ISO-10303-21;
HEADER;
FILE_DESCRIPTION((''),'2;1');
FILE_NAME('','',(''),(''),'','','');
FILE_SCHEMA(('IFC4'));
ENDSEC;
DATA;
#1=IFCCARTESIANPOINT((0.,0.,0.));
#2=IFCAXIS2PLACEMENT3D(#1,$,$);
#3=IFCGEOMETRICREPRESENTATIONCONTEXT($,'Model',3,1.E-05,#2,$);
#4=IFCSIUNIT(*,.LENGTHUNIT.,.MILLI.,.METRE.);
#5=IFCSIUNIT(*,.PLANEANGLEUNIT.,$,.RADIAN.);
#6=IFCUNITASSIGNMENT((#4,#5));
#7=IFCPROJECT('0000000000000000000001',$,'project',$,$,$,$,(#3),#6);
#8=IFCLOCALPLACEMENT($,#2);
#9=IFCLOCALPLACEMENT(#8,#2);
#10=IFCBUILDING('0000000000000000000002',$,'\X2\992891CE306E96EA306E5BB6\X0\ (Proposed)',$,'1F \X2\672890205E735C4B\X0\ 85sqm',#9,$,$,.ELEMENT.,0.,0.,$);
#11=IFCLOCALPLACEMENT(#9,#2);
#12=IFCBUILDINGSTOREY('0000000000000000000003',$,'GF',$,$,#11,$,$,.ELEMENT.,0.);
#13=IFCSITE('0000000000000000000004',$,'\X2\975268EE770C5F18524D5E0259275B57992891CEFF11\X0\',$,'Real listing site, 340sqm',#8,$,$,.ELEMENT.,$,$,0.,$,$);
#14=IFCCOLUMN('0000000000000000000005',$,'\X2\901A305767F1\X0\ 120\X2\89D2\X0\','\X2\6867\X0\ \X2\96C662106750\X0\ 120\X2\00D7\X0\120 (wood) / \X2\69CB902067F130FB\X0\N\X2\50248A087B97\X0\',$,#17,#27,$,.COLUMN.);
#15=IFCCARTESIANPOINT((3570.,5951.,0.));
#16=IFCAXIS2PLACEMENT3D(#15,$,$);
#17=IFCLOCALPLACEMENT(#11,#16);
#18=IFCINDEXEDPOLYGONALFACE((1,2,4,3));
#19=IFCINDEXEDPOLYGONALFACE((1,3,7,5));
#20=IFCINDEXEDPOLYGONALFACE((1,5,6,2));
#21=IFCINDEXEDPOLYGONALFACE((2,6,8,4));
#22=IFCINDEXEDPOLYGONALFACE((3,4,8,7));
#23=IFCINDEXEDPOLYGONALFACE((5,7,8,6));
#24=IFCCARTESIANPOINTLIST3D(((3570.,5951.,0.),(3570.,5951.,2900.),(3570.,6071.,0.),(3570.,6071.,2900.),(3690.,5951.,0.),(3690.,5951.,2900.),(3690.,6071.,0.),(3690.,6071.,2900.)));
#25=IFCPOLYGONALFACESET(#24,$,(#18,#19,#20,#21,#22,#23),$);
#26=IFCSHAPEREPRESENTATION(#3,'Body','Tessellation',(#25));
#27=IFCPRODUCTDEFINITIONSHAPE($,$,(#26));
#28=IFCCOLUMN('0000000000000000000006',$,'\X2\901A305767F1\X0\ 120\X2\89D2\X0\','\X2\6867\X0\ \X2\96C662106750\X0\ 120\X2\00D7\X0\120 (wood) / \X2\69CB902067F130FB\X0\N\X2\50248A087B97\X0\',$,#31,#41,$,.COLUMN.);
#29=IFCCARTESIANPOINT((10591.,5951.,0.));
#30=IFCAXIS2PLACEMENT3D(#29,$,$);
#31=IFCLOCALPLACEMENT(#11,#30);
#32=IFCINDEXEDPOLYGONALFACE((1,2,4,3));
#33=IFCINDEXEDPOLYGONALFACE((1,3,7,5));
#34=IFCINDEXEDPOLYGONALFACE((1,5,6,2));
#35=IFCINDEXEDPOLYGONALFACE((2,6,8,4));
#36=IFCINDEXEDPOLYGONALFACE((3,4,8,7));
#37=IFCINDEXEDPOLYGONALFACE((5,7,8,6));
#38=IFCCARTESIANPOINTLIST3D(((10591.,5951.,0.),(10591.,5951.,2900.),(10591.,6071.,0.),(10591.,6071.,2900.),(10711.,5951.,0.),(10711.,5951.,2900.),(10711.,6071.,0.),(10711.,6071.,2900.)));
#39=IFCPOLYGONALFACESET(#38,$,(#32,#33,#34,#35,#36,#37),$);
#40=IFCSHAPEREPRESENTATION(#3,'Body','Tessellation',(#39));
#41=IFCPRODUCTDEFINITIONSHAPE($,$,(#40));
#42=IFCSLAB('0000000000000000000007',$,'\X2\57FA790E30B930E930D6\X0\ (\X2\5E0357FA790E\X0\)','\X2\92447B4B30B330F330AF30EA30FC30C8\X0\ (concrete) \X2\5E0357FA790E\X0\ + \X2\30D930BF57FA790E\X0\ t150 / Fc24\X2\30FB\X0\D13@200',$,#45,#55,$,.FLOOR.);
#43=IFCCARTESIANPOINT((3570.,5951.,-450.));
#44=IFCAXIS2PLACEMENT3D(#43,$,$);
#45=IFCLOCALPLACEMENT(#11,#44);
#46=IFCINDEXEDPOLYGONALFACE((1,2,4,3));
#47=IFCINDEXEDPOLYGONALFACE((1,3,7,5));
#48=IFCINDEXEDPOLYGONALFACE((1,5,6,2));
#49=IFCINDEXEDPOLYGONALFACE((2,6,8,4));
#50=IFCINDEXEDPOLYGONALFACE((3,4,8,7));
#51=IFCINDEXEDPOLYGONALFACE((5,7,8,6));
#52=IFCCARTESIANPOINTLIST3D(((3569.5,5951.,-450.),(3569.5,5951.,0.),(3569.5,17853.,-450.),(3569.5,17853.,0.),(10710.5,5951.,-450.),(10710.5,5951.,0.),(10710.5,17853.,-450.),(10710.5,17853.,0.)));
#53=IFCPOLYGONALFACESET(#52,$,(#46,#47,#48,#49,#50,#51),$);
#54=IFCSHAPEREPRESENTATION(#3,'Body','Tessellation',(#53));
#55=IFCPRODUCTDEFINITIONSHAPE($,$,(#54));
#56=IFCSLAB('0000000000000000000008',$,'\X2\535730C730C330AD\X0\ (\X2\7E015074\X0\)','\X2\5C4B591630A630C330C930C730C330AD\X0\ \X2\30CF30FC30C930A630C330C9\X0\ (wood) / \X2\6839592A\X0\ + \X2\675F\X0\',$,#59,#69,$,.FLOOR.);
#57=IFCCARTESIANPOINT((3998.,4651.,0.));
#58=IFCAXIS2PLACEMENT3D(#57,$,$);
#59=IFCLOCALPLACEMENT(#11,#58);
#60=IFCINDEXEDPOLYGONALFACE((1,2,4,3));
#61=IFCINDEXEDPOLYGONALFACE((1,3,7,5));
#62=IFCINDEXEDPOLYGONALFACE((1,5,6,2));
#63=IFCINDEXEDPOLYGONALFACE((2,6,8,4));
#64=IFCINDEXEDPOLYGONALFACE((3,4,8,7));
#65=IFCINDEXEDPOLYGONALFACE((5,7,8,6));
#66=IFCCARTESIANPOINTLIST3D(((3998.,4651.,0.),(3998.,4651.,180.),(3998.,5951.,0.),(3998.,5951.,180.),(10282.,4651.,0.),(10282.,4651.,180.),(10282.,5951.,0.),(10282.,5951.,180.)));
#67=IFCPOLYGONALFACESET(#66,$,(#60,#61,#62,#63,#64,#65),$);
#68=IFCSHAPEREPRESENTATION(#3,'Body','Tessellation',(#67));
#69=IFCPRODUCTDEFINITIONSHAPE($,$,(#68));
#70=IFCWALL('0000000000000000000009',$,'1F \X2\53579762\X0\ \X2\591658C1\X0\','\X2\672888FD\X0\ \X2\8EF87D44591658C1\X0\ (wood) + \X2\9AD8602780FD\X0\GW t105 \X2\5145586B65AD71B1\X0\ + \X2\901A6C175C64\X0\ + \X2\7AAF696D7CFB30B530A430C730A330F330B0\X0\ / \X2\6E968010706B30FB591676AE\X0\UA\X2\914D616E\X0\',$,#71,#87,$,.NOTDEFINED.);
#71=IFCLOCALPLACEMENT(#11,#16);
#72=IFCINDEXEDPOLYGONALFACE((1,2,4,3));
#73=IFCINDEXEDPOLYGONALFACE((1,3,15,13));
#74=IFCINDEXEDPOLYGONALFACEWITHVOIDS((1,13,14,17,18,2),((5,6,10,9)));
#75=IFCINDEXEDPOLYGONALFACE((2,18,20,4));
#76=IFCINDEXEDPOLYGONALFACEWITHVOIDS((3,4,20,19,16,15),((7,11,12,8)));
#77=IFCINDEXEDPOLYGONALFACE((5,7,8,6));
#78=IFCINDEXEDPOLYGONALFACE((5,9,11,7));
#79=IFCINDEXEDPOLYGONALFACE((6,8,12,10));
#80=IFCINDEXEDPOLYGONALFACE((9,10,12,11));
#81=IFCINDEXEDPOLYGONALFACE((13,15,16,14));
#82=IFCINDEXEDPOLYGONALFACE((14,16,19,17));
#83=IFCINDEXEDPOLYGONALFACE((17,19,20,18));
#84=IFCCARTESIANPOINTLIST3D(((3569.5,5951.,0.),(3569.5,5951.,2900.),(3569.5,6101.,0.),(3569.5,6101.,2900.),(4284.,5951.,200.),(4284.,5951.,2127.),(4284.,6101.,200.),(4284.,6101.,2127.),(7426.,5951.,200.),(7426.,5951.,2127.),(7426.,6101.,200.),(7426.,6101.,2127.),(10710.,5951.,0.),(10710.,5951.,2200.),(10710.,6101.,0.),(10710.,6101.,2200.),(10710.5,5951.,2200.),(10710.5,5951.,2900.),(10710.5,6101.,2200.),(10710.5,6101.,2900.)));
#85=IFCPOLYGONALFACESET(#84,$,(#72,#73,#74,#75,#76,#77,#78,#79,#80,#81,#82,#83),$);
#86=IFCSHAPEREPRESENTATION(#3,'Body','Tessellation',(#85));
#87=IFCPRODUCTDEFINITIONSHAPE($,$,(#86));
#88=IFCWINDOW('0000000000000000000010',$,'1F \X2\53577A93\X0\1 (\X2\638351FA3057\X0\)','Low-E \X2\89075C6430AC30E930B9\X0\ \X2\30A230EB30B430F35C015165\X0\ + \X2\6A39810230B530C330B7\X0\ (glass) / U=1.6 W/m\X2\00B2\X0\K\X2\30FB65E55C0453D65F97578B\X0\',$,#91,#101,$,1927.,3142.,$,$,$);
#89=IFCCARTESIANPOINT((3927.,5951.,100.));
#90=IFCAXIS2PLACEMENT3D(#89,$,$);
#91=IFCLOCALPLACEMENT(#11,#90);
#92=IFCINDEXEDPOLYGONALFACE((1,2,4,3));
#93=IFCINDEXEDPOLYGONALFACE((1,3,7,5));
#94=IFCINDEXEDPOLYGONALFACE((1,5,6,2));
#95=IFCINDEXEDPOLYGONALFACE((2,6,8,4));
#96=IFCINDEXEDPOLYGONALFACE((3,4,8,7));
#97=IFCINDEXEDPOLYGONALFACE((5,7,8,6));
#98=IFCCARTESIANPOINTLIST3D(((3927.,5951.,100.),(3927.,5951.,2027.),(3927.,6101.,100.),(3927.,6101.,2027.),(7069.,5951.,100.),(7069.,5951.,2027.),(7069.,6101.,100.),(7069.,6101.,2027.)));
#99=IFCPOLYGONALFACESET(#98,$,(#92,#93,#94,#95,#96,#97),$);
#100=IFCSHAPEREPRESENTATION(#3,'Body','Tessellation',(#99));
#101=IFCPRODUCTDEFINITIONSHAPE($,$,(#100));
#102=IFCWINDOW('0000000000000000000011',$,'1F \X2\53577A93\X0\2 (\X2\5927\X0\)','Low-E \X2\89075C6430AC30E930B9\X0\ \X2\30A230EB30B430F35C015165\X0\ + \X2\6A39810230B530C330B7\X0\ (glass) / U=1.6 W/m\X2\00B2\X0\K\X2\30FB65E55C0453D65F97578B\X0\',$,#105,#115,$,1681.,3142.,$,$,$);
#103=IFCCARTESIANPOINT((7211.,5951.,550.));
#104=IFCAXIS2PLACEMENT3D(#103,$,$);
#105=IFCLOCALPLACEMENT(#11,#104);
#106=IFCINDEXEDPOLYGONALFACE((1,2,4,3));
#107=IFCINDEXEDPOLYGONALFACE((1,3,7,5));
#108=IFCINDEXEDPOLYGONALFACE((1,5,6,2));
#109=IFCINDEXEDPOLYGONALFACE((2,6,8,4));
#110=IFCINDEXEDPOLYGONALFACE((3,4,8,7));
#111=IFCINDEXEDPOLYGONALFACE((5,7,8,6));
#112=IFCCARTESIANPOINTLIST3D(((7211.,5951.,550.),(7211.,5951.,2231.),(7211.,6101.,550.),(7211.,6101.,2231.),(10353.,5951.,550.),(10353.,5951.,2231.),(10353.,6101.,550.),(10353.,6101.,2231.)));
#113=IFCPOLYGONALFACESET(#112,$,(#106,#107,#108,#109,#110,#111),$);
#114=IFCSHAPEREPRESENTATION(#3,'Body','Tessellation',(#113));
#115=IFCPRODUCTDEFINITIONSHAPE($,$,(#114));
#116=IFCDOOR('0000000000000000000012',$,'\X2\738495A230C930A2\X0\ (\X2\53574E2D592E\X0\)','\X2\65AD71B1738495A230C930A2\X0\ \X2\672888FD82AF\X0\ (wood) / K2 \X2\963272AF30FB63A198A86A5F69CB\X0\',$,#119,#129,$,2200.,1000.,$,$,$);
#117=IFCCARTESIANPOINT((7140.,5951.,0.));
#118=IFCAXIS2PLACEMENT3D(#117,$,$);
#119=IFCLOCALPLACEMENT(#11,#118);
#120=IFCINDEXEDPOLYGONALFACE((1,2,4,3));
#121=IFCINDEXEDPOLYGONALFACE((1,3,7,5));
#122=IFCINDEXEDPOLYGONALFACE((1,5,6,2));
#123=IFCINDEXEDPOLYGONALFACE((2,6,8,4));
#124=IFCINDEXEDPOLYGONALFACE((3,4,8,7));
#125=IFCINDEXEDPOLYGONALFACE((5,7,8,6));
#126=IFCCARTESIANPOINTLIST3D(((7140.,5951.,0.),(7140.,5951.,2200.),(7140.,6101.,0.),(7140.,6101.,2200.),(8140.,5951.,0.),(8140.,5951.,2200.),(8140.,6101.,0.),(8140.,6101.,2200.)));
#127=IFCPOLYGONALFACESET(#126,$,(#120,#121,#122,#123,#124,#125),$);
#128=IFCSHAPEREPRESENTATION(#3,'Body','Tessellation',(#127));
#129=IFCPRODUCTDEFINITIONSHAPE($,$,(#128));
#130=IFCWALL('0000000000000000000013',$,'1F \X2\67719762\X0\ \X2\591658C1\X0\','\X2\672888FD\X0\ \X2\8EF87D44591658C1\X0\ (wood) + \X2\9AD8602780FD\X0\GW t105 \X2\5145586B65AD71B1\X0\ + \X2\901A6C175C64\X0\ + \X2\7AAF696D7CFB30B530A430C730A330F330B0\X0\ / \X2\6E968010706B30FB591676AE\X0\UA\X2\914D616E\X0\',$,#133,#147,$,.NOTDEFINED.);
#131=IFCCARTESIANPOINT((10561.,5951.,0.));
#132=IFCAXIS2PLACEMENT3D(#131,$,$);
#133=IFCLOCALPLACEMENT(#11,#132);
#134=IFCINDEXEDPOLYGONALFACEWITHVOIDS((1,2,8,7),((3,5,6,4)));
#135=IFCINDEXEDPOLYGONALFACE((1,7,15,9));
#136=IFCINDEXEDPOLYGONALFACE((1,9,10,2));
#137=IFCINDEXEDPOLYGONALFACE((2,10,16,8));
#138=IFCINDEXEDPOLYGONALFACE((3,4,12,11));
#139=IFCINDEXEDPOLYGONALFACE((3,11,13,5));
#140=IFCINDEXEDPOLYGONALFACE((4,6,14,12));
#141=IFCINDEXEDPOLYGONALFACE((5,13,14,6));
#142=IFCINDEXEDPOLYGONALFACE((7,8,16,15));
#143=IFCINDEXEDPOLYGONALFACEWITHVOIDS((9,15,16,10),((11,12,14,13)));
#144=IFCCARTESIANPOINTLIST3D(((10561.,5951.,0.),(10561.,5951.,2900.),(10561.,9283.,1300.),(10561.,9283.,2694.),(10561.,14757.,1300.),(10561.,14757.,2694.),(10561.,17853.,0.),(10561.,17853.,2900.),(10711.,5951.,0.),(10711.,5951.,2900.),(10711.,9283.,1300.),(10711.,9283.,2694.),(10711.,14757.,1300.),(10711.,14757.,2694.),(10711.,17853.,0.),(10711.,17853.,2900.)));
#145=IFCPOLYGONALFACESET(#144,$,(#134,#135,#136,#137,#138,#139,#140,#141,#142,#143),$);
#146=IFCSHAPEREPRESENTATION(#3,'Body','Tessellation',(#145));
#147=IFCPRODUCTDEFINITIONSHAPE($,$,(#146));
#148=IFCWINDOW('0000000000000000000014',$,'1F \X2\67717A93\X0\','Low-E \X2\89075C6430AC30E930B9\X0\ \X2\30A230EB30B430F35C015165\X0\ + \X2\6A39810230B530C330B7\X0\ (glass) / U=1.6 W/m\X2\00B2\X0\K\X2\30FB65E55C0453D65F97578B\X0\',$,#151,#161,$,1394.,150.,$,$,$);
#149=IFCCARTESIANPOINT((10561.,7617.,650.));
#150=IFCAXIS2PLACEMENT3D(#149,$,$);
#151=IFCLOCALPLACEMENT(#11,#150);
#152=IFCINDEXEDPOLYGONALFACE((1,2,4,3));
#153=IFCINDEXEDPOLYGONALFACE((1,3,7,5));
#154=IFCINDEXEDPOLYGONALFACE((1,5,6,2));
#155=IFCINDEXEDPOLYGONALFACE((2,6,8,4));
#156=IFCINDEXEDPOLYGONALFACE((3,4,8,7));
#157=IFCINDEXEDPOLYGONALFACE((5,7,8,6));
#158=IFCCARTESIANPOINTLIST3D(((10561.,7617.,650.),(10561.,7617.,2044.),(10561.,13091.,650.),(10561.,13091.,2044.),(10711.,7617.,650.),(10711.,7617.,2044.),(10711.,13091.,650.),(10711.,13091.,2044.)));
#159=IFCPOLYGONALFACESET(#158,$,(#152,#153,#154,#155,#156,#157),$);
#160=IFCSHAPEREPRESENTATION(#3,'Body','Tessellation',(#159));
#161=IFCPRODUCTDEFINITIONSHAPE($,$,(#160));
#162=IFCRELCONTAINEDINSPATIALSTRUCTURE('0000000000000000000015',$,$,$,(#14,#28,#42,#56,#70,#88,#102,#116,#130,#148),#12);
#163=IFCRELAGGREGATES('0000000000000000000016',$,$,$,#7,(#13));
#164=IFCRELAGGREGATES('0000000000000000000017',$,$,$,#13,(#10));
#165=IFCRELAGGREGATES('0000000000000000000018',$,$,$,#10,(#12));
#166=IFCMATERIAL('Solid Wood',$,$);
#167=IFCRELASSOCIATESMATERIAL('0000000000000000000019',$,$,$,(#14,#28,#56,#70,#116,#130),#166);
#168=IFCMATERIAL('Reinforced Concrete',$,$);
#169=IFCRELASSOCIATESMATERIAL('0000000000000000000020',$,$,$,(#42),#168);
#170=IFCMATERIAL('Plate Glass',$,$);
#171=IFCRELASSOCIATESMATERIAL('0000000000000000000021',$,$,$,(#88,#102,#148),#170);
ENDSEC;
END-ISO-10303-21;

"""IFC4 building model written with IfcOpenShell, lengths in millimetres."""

from ifc_helpers import new_model, si_unit, frame, frame_2d, origin, place, context, project, spatial, rectangle, extrude, material, element, fill, save


model = new_model("IFC4")

# Units and contexts
model_context = context("Model", 3, precision=1e-05, world=origin())
ifc_project = project(units=[si_unit("LENGTHUNIT", "METRE", prefix="MILLI"), si_unit("PLANEANGLEUNIT", "RADIAN")], contexts=[model_context])

# Site, building, storey
site_placement = place(None, origin())
site = spatial("IfcSite", under=ifc_project, at=site_placement, Name="青森県弘前市大字館野１", ObjectType="Real listing site, 340sqm", CompositionType="ELEMENT", RefElevation=0.0)
building_placement = place(site_placement, origin())
building = spatial("IfcBuilding", under=site, at=building_placement, Name="館野の雪の家 (Proposed)", ObjectType="1F 木造平屋 85sqm", CompositionType="ELEMENT", ElevationOfRefHeight=0.0, ElevationOfTerrain=0.0)
storey_placement = place(building_placement, origin())
storey = spatial("IfcBuildingStorey", under=building, at=storey_placement, Name="GF", CompositionType="ELEMENT", Elevation=0.0)

# Columns
ifc_material_1 = material(Name="Solid Wood")
column_1_placement = place(storey_placement, frame((3570.0, 5951.0, 0.0)))
element("IfcColumn", 1, at=column_1_placement, inside=storey, material=ifc_material_1, Name="通し柱 120角", Description="桧 集成材 120×120 (wood) / 構造柱・N値計算", PredefinedType="COLUMN", context=model_context, shape_type="SweptSolid", body=[
    extrude(rectangle(XDim=120.0, YDim=120.0, at=frame_2d((60.0, 60.0))), frame((3570.0, 5951.0, 0.0)), (0.0, 0.0, 1.0), 2900.0),
])
column_2_placement = place(storey_placement, frame((10591.0, 5951.0, 0.0)))
element("IfcColumn", 2, at=column_2_placement, inside=storey, material=ifc_material_1, Name="通し柱 120角", Description="桧 集成材 120×120 (wood) / 構造柱・N値計算", PredefinedType="COLUMN", context=model_context, shape_type="SweptSolid", body=[
    extrude(rectangle(XDim=120.0, YDim=120.0, at=frame_2d((60.0, 60.0))), frame((10591.0, 5951.0, 0.0)), (0.0, 0.0, 1.0), 2900.0),
])

# Slabs
ifc_material_2 = material(Name="Reinforced Concrete")
slab_1_placement = place(storey_placement, frame((3570.0, 5951.0, -450.0)))
element("IfcSlab", 3, at=slab_1_placement, inside=storey, material=ifc_material_2, Name="基礎スラブ (布基礎)", Description="鉄筋コンクリート (concrete) 布基礎 + ベタ基礎 t150 / Fc24・D13@200", PredefinedType="FLOOR", context=model_context, shape_type="SweptSolid", body=[
    extrude(rectangle(XDim=7141.0, YDim=11902.0, at=frame_2d((3570.0, 5951.0))), frame((3570.0, 5951.0, -450.0)), (0.0, 0.0, 1.0), 450.0),
])
slab_2_placement = place(storey_placement, frame((3998.0, 4651.0, 0.0)))
element("IfcSlab", 4, at=slab_2_placement, inside=storey, material=ifc_material_1, Name="南デッキ (縁側)", Description="屋外ウッドデッキ ハードウッド (wood) / 根太 + 束", PredefinedType="FLOOR", context=model_context, shape_type="SweptSolid", body=[
    extrude(rectangle(XDim=6284.0, YDim=1300.0, at=frame_2d((3142.0, 650.0))), frame((3998.0, 4651.0, 0.0)), (0.0, 0.0, 1.0), 180.0),
])

# Wall, openings, windows, door
wall_1_placement = place(storey_placement, frame((3570.0, 5951.0, 0.0)))
wall_1 = element("IfcWall", 5, at=wall_1_placement, inside=storey, material=ifc_material_1, Name="1F 南面 外壁", Description="木製 軸組外壁 (wood) + 高性能GW t105 充填断熱 + 通気層 + 窯業系サイディング / 準耐火・外皮UA配慮", PredefinedType="NOTDEFINED", context=model_context, shape_type="SweptSolid", body=[
    extrude(rectangle(XDim=7141.0, YDim=150.0, at=frame_2d((3570.0, 75.0))), frame((3570.0, 5951.0, 0.0)), (0.0, 0.0, 1.0), 2900.0),
])
opening_1_placement = place(storey_placement, frame((3927.0, 5951.0, 100.0)))
opening_1 = element("IfcOpeningElement", 6, at=opening_1_placement, cuts=wall_1, PredefinedType="NOTDEFINED", context=model_context, shape_type="SweptSolid", body=[
    extrude(rectangle(XDim=3142.0, YDim=150.0, at=frame_2d((1571.0, 75.0))), frame((3927.0, 5951.0, 100.0)), (0.0, 0.0, 1.0), 1927.0),
])
opening_2_placement = place(storey_placement, frame((7211.0, 5951.0, 550.0)))
opening_2 = element("IfcOpeningElement", 7, at=opening_2_placement, cuts=wall_1, PredefinedType="NOTDEFINED", context=model_context, shape_type="SweptSolid", body=[
    extrude(rectangle(XDim=3142.0, YDim=150.0, at=frame_2d((1571.0, 75.0))), frame((7211.0, 5951.0, 550.0)), (0.0, 0.0, 1.0), 1681.0),
])
opening_3_placement = place(storey_placement, frame((7140.0, 5951.0, 0.0)))
opening_3 = element("IfcOpeningElement", 8, at=opening_3_placement, cuts=wall_1, PredefinedType="NOTDEFINED", context=model_context, shape_type="SweptSolid", body=[
    extrude(rectangle(XDim=1000.0, YDim=150.0, at=frame_2d((500.0, 75.0))), frame((7140.0, 5951.0, 0.0)), (0.0, 0.0, 1.0), 2200.0),
])
ifc_material_3 = material(Name="Plate Glass")
window_1_placement = place(storey_placement, frame((3927.0, 5951.0, 100.0)))
window_1 = element("IfcWindow", 9, at=window_1_placement, inside=storey, material=ifc_material_3, Name="1F 南窓1 (掃出し)", Description="Low-E 複層ガラス アルゴン封入 + 樹脂サッシ (glass) / U=1.6 W/m²K・日射取得型", OverallHeight=1927.0, OverallWidth=3142.0, context=model_context, shape_type="SweptSolid", body=[
    extrude(rectangle(XDim=3142.0, YDim=150.0, at=frame_2d((1571.0, 75.0))), frame((3927.0, 5951.0, 100.0)), (0.0, 0.0, 1.0), 1927.0),
])
fill(opening_1, window_1)
window_2_placement = place(storey_placement, frame((7211.0, 5951.0, 550.0)))
window_2 = element("IfcWindow", 10, at=window_2_placement, inside=storey, material=ifc_material_3, Name="1F 南窓2 (大)", Description="Low-E 複層ガラス アルゴン封入 + 樹脂サッシ (glass) / U=1.6 W/m²K・日射取得型", OverallHeight=1681.0, OverallWidth=3142.0, context=model_context, shape_type="SweptSolid", body=[
    extrude(rectangle(XDim=3142.0, YDim=150.0, at=frame_2d((1571.0, 75.0))), frame((7211.0, 5951.0, 550.0)), (0.0, 0.0, 1.0), 1681.0),
])
fill(opening_2, window_2)
door_placement = place(storey_placement, frame((7140.0, 5951.0, 0.0)))
door = element("IfcDoor", 11, at=door_placement, inside=storey, material=ifc_material_1, Name="玄関ドア (南中央)", Description="断熱玄関ドア 木製芯 (wood) / K2 防犯・採風機構", OverallHeight=2200.0, OverallWidth=1000.0, context=model_context, shape_type="SweptSolid", body=[
    extrude(rectangle(XDim=1000.0, YDim=150.0, at=frame_2d((500.0, 75.0))), frame((7140.0, 5951.0, 0.0)), (0.0, 0.0, 1.0), 2200.0),
])
fill(opening_3, door)

# Wall, opening, window
wall_2_placement = place(storey_placement, frame((10561.0, 5951.0, 0.0)))
wall_2 = element("IfcWall", 12, at=wall_2_placement, inside=storey, material=ifc_material_1, Name="1F 東面 外壁", Description="木製 軸組外壁 (wood) + 高性能GW t105 充填断熱 + 通気層 + 窯業系サイディング / 準耐火・外皮UA配慮", PredefinedType="NOTDEFINED", context=model_context, shape_type="SweptSolid", body=[
    extrude(rectangle(XDim=150.0, YDim=11902.0, at=frame_2d((75.0, 5951.0))), frame((10561.0, 5951.0, 0.0)), (0.0, 0.0, 1.0), 2900.0),
])
opening_4_placement = place(storey_placement, frame((10561.0, 7617.0, 650.0)))
opening_4 = element("IfcOpeningElement", 13, at=opening_4_placement, cuts=wall_2, PredefinedType="NOTDEFINED", context=model_context, shape_type="SweptSolid", body=[
    extrude(rectangle(XDim=150.0, YDim=5474.0, at=frame_2d((75.0, 2737.0))), frame((10561.0, 7617.0, 650.0)), (0.0, 0.0, 1.0), 1394.0),
])
window_3_placement = place(storey_placement, frame((10561.0, 7617.0, 650.0)))
window_3 = element("IfcWindow", 14, at=window_3_placement, inside=storey, material=ifc_material_3, Name="1F 東窓", Description="Low-E 複層ガラス アルゴン封入 + 樹脂サッシ (glass) / U=1.6 W/m²K・日射取得型", OverallHeight=1394.0, OverallWidth=150.0, context=model_context, shape_type="SweptSolid", body=[
    extrude(rectangle(XDim=150.0, YDim=5474.0, at=frame_2d((75.0, 2737.0))), frame((10561.0, 7617.0, 650.0)), (0.0, 0.0, 1.0), 1394.0),
])
fill(opening_4, window_3)

save(model, "model.ifc")
